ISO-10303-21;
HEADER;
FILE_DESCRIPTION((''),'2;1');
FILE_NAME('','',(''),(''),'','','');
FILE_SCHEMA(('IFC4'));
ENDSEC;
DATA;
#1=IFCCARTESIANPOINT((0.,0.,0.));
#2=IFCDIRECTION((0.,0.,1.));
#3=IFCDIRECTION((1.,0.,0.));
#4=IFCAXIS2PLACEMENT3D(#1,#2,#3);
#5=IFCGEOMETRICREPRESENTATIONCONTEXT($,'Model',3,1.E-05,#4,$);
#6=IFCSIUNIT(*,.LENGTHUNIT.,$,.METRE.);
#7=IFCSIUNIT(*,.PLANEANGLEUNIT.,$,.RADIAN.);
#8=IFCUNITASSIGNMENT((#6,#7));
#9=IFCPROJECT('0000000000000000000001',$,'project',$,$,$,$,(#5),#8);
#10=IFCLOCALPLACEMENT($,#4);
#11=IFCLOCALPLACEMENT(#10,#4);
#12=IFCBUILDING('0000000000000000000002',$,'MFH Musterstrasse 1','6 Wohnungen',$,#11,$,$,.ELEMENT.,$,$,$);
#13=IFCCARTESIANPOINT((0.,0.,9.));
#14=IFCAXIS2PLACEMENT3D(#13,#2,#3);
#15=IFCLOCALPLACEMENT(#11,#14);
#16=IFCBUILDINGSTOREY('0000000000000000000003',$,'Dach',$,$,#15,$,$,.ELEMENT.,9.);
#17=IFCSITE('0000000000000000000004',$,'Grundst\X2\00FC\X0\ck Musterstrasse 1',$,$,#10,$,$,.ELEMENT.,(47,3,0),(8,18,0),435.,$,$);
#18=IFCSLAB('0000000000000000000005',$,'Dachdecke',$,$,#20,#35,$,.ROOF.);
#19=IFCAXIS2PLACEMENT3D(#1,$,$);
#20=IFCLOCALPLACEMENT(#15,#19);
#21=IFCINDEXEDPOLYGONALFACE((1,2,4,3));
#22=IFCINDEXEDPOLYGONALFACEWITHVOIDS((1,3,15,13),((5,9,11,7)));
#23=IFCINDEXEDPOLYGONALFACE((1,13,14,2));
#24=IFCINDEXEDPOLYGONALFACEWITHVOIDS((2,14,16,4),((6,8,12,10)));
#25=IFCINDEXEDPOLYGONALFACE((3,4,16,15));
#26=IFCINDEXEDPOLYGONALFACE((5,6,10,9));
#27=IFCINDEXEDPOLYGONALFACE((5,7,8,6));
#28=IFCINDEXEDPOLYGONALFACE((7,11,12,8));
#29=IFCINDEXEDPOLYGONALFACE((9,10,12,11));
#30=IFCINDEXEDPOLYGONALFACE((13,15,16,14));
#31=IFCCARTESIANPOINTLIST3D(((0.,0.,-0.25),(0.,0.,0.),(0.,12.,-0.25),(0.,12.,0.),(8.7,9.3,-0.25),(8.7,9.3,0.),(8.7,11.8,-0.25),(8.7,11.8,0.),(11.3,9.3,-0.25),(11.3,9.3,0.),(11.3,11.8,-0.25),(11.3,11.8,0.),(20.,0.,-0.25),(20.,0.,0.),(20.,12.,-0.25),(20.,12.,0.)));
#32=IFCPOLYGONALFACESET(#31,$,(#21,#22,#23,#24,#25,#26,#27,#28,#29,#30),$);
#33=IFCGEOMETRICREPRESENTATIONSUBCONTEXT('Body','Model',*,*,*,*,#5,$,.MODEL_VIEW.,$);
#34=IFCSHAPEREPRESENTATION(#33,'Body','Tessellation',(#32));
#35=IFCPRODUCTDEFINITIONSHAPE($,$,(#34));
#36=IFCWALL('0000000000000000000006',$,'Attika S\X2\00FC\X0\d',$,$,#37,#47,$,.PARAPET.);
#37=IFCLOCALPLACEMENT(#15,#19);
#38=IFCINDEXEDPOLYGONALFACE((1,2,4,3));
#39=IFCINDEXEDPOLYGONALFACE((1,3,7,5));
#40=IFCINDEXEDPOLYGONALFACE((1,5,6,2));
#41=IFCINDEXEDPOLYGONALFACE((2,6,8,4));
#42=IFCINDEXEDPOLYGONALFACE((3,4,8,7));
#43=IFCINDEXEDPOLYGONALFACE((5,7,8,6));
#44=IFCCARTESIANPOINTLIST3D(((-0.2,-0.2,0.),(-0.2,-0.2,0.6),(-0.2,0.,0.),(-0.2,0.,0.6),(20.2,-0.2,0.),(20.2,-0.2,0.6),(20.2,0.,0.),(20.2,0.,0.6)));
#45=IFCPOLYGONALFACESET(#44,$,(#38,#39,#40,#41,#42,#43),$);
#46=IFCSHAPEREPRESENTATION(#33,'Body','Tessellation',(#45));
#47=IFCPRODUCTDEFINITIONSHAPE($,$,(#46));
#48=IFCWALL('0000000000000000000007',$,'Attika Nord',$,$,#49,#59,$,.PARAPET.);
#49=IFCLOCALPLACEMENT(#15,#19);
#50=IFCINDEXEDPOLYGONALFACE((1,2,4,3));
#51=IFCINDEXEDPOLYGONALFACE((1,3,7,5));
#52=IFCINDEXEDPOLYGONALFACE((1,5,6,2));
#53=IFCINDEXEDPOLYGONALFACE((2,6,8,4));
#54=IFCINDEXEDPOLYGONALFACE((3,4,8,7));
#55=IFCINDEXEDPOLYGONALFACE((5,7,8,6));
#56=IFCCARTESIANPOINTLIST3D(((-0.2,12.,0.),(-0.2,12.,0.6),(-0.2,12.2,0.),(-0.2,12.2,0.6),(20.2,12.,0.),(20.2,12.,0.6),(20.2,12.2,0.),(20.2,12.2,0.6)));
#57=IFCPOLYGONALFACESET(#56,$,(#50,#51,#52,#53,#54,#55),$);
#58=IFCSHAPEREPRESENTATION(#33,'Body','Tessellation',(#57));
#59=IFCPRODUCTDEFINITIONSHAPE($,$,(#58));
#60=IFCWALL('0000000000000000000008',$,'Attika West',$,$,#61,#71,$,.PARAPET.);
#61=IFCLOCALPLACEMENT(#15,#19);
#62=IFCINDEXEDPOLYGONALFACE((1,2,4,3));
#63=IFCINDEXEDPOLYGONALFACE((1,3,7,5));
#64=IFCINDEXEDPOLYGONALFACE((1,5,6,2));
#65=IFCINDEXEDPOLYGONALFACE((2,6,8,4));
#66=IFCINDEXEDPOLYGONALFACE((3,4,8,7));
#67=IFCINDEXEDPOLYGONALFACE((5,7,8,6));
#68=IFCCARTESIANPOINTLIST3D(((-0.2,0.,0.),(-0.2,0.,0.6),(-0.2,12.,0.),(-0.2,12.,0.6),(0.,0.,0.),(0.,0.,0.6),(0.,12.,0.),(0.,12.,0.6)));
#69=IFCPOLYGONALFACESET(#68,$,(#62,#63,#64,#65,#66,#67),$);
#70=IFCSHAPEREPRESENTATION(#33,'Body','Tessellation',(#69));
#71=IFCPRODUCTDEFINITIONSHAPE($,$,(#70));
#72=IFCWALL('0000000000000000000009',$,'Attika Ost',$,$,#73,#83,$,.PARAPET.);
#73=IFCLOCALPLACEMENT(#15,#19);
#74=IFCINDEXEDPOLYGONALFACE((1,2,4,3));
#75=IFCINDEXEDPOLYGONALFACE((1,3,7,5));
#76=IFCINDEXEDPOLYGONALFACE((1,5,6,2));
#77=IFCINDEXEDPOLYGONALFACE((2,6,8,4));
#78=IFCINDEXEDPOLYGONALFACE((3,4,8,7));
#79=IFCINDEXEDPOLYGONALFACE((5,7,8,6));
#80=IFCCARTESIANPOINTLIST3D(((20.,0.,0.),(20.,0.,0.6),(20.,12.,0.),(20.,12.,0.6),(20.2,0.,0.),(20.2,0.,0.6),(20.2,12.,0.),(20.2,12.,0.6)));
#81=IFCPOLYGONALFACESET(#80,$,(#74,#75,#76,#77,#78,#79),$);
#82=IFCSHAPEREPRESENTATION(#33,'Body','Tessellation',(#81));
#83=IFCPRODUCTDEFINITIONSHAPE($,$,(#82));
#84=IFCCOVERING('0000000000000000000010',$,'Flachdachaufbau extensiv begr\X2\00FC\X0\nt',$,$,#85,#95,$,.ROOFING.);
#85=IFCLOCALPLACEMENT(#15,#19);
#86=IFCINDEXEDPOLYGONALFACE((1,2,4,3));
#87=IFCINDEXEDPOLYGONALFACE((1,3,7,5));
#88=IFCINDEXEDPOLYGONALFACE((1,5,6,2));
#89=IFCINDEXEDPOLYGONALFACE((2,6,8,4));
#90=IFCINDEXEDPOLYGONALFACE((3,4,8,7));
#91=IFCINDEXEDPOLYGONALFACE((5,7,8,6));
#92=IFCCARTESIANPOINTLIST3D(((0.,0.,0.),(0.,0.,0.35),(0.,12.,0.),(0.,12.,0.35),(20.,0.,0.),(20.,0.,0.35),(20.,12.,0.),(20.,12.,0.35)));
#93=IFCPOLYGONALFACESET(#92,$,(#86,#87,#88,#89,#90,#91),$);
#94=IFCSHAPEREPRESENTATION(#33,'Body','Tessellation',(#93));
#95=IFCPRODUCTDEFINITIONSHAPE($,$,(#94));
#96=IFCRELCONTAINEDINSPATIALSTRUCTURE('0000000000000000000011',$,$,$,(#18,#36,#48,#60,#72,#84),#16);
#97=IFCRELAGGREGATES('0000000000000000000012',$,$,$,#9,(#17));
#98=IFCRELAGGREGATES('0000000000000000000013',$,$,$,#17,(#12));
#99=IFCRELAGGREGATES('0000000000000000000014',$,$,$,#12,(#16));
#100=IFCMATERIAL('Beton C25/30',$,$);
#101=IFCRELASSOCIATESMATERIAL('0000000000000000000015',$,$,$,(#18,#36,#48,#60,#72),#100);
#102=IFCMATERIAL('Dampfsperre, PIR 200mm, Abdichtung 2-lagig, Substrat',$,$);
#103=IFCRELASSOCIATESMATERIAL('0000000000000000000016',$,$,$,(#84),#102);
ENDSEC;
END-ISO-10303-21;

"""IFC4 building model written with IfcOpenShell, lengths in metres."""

from ifc_helpers import new_model, si_unit, frame, frame_2d, origin_with_axes, place, context, subcontext, project, spatial, rectangle, extrude, material, element, save


model = new_model("IFC4")

# Units and contexts
model_context = context("Model", 3, precision=1e-05, world=origin_with_axes())
body_context = subcontext(model_context, "Body", "Model", "MODEL_VIEW")
ifc_project = project(units=[si_unit("LENGTHUNIT", "METRE"), si_unit("PLANEANGLEUNIT", "RADIAN")], contexts=[model_context])

# Site, building, storey
site_placement = place(None, origin_with_axes())
site = spatial("IfcSite", under=ifc_project, at=site_placement, Name="Grundstück Musterstrasse 1", CompositionType="ELEMENT", RefLatitude=(47, 3, 0), RefLongitude=(8, 18, 0), RefElevation=435.0)
building_placement = place(site_placement, origin_with_axes())
building = spatial("IfcBuilding", under=site, at=building_placement, Name="MFH Musterstrasse 1", Description="6 Wohnungen", CompositionType="ELEMENT")
storey_placement = place(building_placement, frame((0.0, 0.0, 9.0), z_axis=(0.0, 0.0, 1.0), x_axis=(1.0, 0.0, 0.0)))
storey = spatial("IfcBuildingStorey", under=building, at=storey_placement, Name="Dach", CompositionType="ELEMENT", Elevation=9.0)

# Slab, opening
ifc_material_1 = material(Name="Beton C25/30")
slab_placement = place(storey_placement, origin_with_axes())
slab = element("IfcSlab", 1, at=slab_placement, inside=storey, material=ifc_material_1, Name="Dachdecke", PredefinedType="ROOF", context=body_context, shape_type="SweptSolid", body=[
    extrude(rectangle(XDim=20.0, YDim=12.0, at=frame_2d((10.0, 6.0), x_axis=(1.0, 0.0))), frame((0.0, 0.0, -0.25), z_axis=(0.0, 0.0, 1.0), x_axis=(1.0, 0.0, 0.0)), (0.0, 0.0, 1.0), 0.25),
])
opening_placement = place(storey_placement, origin_with_axes())
element("IfcOpeningElement", 2, at=opening_placement, cuts=slab, PredefinedType="OPENING", context=body_context, shape_type="SweptSolid", body=[
    extrude(rectangle(XDim=2.6, YDim=2.5, at=frame_2d((1.3, 1.25), x_axis=(1.0, 0.0))), frame((8.7, 9.3, -0.26), z_axis=(0.0, 0.0, 1.0), x_axis=(1.0, 0.0, 0.0)), (0.0, 0.0, 1.0), 0.27),
])

# Walls
wall_1_placement = place(storey_placement, origin_with_axes())
element("IfcWall", 3, at=wall_1_placement, inside=storey, material=ifc_material_1, Name="Attika Süd", PredefinedType="PARAPET", context=body_context, shape_type="SweptSolid", body=[
    extrude(rectangle(XDim=20.4, YDim=0.2, at=frame_2d((10.2, 0.1), x_axis=(1.0, 0.0))), frame((-0.2, -0.2, 0.0), z_axis=(0.0, 0.0, 1.0), x_axis=(1.0, 0.0, 0.0)), (0.0, 0.0, 1.0), 0.6),
])
wall_2_placement = place(storey_placement, origin_with_axes())
element("IfcWall", 4, at=wall_2_placement, inside=storey, material=ifc_material_1, Name="Attika Nord", PredefinedType="PARAPET", context=body_context, shape_type="SweptSolid", body=[
    extrude(rectangle(XDim=20.4, YDim=0.2, at=frame_2d((10.2, 0.1), x_axis=(1.0, 0.0))), frame((-0.2, 12.0, 0.0), z_axis=(0.0, 0.0, 1.0), x_axis=(1.0, 0.0, 0.0)), (0.0, 0.0, 1.0), 0.6),
])
wall_3_placement = place(storey_placement, origin_with_axes())
element("IfcWall", 5, at=wall_3_placement, inside=storey, material=ifc_material_1, Name="Attika West", PredefinedType="PARAPET", context=body_context, shape_type="SweptSolid", body=[
    extrude(rectangle(XDim=0.2, YDim=12.0, at=frame_2d((0.1, 6.0), x_axis=(1.0, 0.0))), frame((-0.2, 0.0, 0.0), z_axis=(0.0, 0.0, 1.0), x_axis=(1.0, 0.0, 0.0)), (0.0, 0.0, 1.0), 0.6),
])
wall_4_placement = place(storey_placement, origin_with_axes())
element("IfcWall", 6, at=wall_4_placement, inside=storey, material=ifc_material_1, Name="Attika Ost", PredefinedType="PARAPET", context=body_context, shape_type="SweptSolid", body=[
    extrude(rectangle(XDim=0.2, YDim=12.0, at=frame_2d((0.1, 6.0), x_axis=(1.0, 0.0))), frame((20.0, 0.0, 0.0), z_axis=(0.0, 0.0, 1.0), x_axis=(1.0, 0.0, 0.0)), (0.0, 0.0, 1.0), 0.6),
])

# Covering
ifc_material_2 = material(Name="Dampfsperre, PIR 200mm, Abdichtung 2-lagig, Substrat")
covering_placement = place(storey_placement, origin_with_axes())
element("IfcCovering", 7, at=covering_placement, inside=storey, material=ifc_material_2, Name="Flachdachaufbau extensiv begrünt", PredefinedType="ROOFING", context=body_context, shape_type="SweptSolid", body=[
    extrude(rectangle(XDim=20.0, YDim=12.0, at=frame_2d((10.0, 6.0), x_axis=(1.0, 0.0))), origin_with_axes(), (0.0, 0.0, 1.0), 0.35),
])

save(model, "model.ifc")
